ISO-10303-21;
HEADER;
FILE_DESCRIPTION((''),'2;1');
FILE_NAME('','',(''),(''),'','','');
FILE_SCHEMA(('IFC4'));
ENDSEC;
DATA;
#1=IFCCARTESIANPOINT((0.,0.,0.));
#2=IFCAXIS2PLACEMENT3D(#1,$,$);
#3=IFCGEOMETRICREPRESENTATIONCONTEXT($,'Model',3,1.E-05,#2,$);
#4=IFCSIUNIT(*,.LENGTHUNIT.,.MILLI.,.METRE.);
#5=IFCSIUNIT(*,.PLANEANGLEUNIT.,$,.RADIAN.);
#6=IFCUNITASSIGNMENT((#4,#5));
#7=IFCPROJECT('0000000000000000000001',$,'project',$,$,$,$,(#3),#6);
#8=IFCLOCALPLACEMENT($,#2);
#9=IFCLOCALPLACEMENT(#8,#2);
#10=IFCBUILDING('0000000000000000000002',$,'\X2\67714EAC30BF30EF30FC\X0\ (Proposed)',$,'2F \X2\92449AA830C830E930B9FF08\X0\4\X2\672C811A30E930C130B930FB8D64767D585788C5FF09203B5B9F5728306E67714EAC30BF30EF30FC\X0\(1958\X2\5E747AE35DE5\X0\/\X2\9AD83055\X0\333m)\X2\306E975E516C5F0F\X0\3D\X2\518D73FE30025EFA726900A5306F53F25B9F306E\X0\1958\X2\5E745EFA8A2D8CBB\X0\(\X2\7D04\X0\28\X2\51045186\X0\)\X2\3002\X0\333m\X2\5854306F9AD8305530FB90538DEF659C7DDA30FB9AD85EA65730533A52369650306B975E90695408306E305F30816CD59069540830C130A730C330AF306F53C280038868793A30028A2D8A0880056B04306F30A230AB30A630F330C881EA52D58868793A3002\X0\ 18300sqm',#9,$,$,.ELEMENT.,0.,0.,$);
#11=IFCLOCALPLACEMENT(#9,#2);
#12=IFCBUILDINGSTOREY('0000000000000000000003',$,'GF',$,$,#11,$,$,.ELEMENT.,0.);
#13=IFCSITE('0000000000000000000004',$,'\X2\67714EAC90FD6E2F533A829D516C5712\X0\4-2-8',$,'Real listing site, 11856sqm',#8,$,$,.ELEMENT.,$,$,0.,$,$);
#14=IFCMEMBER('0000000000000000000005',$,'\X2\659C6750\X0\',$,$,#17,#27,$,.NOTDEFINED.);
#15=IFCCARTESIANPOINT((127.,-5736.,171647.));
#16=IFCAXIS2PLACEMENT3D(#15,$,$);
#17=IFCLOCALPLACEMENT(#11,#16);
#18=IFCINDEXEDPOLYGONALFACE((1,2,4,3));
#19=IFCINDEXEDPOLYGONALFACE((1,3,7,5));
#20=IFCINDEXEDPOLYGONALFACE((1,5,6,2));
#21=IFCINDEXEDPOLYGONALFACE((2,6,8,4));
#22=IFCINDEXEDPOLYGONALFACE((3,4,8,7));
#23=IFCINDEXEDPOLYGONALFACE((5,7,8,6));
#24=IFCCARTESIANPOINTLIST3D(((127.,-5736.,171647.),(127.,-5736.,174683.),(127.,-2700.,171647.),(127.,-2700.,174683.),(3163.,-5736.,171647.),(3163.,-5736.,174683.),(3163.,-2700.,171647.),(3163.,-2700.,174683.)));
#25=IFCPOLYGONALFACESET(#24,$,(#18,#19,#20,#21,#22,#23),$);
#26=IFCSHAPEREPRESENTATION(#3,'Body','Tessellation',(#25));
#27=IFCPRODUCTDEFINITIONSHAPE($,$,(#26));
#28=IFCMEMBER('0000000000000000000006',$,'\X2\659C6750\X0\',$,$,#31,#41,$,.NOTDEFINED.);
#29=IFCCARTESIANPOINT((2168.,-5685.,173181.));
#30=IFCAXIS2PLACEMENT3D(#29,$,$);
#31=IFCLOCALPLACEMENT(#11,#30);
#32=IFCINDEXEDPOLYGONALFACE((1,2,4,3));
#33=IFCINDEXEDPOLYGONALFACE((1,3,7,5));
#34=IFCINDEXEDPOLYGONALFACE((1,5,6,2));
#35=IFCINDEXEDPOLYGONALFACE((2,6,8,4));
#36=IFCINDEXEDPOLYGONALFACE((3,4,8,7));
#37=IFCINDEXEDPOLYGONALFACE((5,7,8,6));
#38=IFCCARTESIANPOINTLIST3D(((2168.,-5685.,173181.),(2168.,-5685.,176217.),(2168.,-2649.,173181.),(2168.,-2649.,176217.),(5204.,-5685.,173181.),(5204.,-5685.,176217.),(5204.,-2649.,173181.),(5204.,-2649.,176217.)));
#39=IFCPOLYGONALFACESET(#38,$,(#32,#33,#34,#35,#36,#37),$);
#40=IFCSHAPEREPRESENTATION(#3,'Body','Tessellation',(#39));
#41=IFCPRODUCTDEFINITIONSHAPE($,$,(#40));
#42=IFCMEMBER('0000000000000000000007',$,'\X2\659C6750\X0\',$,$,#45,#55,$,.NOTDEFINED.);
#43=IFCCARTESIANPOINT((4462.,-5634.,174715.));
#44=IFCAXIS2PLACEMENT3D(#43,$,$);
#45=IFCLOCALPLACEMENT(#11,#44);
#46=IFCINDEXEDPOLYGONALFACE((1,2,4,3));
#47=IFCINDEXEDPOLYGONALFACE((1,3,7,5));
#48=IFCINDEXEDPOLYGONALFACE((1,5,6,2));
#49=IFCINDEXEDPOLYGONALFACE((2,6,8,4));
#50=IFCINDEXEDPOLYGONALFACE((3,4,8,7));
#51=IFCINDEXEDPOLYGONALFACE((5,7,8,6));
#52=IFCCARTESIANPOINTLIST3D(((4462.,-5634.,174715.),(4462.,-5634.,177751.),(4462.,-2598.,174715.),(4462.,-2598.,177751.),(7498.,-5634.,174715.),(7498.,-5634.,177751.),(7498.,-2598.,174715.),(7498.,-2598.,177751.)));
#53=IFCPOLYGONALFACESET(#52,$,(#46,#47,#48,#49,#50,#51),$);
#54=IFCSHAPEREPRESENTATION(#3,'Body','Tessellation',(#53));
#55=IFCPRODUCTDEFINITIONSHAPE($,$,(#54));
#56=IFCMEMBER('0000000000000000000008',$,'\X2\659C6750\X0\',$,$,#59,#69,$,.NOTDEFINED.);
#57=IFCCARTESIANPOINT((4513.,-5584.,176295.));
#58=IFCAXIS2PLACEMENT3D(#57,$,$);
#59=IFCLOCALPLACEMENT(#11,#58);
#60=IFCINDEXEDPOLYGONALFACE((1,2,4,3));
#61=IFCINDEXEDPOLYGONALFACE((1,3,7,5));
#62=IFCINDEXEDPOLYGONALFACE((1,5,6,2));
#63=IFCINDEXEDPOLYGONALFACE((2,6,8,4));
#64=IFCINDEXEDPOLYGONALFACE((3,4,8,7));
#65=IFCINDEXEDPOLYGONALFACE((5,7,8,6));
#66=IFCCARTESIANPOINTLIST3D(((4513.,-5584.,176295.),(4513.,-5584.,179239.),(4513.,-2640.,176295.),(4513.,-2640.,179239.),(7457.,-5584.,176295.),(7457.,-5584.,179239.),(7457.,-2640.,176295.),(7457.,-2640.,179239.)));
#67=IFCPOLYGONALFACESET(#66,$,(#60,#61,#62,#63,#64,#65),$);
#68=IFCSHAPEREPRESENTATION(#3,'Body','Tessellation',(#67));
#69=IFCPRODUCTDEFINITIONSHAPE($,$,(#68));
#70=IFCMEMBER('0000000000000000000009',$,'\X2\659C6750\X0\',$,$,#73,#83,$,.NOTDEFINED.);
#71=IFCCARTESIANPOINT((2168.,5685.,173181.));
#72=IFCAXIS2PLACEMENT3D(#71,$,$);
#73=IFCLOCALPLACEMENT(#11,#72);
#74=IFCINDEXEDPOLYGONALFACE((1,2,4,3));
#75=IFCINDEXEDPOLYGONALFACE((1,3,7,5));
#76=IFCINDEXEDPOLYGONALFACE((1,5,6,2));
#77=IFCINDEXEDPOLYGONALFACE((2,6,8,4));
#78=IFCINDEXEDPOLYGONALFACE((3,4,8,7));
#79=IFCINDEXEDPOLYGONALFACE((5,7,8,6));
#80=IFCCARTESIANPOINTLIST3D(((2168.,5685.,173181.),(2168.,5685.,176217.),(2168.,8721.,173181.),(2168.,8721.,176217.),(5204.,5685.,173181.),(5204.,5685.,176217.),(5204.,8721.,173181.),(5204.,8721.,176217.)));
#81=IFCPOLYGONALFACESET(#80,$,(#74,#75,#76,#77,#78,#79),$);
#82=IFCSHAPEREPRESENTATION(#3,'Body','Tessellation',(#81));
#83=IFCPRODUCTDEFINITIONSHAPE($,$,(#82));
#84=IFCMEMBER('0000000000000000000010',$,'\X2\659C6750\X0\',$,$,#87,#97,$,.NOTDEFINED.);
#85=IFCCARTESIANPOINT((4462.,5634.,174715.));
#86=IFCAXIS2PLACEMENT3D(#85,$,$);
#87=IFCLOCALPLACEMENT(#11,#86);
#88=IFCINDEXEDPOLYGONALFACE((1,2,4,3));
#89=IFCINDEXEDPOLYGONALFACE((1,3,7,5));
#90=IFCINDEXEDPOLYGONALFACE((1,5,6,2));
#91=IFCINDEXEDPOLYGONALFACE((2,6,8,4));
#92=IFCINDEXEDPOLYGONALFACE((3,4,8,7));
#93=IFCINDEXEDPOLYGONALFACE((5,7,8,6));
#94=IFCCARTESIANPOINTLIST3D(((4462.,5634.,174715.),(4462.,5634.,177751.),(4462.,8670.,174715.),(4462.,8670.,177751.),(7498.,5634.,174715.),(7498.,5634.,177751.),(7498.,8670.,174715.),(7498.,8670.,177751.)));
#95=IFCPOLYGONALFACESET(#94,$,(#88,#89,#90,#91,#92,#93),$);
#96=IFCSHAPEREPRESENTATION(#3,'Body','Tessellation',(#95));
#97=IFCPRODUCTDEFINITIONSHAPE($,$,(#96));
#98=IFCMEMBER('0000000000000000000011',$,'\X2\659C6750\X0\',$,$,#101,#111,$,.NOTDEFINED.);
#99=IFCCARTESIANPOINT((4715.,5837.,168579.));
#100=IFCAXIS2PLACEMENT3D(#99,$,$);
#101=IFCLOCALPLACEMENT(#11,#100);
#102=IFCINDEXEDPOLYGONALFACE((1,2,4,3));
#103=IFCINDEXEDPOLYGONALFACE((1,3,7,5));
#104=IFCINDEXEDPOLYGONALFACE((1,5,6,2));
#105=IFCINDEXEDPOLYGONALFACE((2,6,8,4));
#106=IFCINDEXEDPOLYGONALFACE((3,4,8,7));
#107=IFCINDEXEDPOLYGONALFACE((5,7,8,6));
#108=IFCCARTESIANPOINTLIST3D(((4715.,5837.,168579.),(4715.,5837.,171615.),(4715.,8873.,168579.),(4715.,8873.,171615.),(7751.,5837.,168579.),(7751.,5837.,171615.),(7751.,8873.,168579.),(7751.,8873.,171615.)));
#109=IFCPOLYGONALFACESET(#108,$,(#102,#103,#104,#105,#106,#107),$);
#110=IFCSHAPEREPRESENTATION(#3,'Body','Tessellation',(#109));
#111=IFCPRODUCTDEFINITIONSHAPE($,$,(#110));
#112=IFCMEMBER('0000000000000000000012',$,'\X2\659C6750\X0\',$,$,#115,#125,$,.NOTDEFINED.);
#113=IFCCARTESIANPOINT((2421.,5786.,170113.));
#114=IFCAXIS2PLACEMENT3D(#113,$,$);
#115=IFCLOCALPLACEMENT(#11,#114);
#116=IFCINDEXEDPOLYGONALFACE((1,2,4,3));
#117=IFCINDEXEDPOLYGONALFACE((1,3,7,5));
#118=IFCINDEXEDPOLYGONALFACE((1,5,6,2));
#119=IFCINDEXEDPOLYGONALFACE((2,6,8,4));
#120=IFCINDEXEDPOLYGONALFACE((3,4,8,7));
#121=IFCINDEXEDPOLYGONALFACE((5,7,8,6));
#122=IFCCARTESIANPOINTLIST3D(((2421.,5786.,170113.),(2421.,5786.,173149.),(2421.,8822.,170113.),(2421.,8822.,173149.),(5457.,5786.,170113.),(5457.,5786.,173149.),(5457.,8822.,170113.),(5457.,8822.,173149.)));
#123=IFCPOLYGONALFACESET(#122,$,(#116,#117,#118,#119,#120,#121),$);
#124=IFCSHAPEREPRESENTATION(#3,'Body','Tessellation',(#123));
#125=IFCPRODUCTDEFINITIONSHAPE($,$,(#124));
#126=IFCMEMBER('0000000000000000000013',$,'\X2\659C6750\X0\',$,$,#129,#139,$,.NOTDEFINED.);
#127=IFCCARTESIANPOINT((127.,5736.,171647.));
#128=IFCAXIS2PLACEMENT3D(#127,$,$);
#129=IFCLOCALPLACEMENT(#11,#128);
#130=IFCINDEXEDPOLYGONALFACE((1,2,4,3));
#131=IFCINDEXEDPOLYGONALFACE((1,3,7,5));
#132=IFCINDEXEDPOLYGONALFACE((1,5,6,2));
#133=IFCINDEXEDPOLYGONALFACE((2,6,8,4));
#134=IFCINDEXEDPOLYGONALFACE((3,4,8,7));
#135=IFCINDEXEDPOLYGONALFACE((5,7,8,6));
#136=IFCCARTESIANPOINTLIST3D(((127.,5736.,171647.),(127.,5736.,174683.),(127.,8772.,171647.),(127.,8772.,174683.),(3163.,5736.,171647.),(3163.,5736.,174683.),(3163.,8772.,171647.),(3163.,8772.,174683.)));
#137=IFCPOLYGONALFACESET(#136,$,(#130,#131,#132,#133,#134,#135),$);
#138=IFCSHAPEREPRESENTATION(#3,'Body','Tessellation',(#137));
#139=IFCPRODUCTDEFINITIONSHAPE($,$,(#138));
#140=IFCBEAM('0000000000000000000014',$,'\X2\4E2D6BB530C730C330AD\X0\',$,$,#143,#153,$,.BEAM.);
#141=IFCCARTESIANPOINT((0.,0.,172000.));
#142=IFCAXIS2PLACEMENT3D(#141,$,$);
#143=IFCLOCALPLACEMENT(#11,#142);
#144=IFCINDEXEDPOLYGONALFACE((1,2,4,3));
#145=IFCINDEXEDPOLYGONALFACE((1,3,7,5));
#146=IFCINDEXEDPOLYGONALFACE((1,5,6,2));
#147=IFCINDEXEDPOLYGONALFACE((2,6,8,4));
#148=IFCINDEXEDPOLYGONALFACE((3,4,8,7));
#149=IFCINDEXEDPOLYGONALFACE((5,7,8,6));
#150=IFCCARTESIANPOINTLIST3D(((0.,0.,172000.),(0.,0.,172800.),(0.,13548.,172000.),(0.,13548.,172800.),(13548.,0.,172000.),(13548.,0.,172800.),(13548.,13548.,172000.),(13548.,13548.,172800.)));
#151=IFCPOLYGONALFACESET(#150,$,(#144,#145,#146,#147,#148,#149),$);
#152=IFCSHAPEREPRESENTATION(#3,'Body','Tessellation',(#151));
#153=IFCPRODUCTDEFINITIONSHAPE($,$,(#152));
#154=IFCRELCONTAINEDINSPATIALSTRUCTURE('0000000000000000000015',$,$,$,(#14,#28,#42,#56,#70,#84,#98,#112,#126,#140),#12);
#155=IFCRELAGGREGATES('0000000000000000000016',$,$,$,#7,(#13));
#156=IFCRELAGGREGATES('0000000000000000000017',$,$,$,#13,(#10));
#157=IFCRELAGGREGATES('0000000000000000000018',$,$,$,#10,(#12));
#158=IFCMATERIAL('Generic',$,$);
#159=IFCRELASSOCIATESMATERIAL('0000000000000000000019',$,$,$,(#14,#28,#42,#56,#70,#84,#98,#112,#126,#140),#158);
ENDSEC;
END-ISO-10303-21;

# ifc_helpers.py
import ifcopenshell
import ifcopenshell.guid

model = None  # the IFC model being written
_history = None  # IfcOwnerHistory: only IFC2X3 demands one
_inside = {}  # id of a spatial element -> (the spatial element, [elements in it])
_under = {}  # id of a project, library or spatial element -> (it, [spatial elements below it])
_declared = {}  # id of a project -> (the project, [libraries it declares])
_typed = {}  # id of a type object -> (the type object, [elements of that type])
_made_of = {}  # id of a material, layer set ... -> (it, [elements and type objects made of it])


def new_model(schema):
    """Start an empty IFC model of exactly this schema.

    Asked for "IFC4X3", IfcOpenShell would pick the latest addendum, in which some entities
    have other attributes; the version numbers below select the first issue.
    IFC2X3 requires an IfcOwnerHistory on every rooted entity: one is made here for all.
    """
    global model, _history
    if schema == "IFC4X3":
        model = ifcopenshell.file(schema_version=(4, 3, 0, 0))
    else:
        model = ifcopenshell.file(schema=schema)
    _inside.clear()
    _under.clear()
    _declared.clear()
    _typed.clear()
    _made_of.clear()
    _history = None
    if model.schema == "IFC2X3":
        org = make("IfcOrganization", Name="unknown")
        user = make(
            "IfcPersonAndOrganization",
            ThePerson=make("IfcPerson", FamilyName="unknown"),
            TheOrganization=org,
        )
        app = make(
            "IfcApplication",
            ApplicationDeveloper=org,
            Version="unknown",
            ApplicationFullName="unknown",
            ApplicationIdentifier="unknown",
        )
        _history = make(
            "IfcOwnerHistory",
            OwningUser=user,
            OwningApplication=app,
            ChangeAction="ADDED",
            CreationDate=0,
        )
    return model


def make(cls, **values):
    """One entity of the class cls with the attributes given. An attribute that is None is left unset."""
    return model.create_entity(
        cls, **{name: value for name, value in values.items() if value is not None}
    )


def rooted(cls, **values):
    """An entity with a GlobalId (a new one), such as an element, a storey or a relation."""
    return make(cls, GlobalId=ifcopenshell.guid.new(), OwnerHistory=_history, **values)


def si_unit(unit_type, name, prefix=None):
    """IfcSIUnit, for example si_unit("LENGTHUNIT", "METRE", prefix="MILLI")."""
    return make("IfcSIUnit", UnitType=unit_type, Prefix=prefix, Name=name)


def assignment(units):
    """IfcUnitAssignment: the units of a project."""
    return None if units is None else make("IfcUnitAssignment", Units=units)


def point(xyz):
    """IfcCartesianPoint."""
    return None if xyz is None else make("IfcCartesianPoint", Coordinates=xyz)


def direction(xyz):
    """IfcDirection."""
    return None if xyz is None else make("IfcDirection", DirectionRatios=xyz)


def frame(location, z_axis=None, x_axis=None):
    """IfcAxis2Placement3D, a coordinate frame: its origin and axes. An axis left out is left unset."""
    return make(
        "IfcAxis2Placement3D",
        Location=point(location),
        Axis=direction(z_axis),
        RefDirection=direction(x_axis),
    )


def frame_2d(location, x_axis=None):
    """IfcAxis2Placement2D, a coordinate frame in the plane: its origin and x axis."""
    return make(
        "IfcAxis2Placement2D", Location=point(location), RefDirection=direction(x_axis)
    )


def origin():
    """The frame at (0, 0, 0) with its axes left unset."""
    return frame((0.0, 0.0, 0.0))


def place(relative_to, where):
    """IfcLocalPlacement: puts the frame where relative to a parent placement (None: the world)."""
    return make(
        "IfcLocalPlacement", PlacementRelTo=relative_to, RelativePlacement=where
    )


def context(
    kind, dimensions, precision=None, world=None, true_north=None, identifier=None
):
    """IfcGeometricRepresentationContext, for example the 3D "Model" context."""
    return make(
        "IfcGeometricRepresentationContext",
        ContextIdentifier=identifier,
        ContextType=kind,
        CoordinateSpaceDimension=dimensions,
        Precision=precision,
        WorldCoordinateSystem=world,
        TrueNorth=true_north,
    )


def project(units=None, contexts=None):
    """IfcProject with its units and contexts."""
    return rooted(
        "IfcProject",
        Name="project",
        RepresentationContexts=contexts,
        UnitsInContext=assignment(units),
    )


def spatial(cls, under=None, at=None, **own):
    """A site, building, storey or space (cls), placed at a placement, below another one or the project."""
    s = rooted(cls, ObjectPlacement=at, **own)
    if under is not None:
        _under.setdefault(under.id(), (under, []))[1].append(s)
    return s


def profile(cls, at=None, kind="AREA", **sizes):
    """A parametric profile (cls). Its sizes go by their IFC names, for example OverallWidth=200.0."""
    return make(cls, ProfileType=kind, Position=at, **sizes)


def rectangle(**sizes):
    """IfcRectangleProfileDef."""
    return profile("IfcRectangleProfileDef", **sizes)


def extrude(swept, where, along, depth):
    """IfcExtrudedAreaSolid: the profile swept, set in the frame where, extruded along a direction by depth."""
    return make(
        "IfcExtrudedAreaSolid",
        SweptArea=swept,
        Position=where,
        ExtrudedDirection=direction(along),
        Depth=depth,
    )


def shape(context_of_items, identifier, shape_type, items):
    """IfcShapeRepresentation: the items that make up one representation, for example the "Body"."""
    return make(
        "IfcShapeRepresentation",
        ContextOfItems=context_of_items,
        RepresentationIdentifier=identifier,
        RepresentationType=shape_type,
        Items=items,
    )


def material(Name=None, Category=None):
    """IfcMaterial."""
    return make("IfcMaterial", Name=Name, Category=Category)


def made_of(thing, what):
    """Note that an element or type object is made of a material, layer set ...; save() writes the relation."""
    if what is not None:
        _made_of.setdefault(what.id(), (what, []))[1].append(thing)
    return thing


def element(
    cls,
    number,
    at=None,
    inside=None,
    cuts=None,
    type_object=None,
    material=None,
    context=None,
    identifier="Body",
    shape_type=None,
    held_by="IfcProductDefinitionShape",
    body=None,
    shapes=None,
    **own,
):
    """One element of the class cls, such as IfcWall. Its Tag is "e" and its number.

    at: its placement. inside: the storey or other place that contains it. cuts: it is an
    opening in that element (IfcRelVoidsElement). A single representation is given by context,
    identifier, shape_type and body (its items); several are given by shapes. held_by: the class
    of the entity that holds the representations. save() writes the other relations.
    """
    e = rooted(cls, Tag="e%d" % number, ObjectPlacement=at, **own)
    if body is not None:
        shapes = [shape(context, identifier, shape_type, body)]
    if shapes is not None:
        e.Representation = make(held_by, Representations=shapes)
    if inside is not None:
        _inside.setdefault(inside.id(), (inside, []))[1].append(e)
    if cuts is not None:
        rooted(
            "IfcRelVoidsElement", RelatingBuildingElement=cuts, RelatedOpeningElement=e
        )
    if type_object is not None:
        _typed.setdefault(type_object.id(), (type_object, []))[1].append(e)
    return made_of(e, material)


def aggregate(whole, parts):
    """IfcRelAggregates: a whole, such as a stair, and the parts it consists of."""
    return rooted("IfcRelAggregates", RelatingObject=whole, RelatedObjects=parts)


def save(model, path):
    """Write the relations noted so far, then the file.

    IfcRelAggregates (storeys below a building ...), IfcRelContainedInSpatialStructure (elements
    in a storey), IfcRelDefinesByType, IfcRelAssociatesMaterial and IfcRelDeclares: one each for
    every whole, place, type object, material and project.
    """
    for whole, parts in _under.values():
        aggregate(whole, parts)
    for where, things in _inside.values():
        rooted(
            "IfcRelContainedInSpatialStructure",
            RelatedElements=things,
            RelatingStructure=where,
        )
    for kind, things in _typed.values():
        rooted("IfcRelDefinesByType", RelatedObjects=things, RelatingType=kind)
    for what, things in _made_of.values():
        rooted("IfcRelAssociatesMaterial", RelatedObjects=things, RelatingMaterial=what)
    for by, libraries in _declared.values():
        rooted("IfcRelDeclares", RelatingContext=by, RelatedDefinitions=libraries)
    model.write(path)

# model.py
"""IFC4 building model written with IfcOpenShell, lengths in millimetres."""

from ifc_helpers import new_model, si_unit, frame, frame_2d, origin, place, context, project, spatial, rectangle, extrude, material, element, save


model = new_model("IFC4")

# Units and contexts
model_context = context("Model", 3, precision=1e-05, world=origin())
ifc_project = project(units=[si_unit("LENGTHUNIT", "METRE", prefix="MILLI"), si_unit("PLANEANGLEUNIT", "RADIAN")], contexts=[model_context])

# Site, building, storey
site_placement = place(None, origin())
site = spatial("IfcSite", under=ifc_project, at=site_placement, Name="東京都港区芝公園4-2-8", ObjectType="Real listing site, 11856sqm", CompositionType="ELEMENT", RefElevation=0.0)
building_placement = place(site_placement, origin())
building = spatial("IfcBuilding", under=site, at=building_placement, Name="東京タワー (Proposed)", ObjectType="2F 鉄骨トラス（4本脚ラチス・赤白塗装）※実在の東京タワー(1958年竣工/高さ333m)の非公式3D再現。建物¥は史実の1958年建設費(約28億円)。333m塔は高さ・道路斜線・高度地区制限に非適合のため法適合チェックは参考表示。設計者欄はアカウント自動表示。 18300sqm", CompositionType="ELEMENT", ElevationOfRefHeight=0.0, ElevationOfTerrain=0.0)
storey_placement = place(building_placement, origin())
storey = spatial("IfcBuildingStorey", under=building, at=storey_placement, Name="GF", CompositionType="ELEMENT", Elevation=0.0)

# Shared definitions
ifc_material = material(Name="Generic")

# Members
member_1_placement = place(storey_placement, frame((127.0, -5736.0, 171647.0)))
element("IfcMember", 1, at=member_1_placement, inside=storey, material=ifc_material, Name="斜材", PredefinedType="NOTDEFINED", context=model_context, shape_type="SweptSolid", body=[
    extrude(rectangle(XDim=3036.0, YDim=3036.0, at=frame_2d((1518.0, 1518.0))), frame((127.0, -5736.0, 171647.0)), (0.0, 0.0, 1.0), 3036.0),
])
member_2_placement = place(storey_placement, frame((2168.0, -5685.0, 173181.0)))
element("IfcMember", 2, at=member_2_placement, inside=storey, material=ifc_material, Name="斜材", PredefinedType="NOTDEFINED", context=model_context, shape_type="SweptSolid", body=[
    extrude(rectangle(XDim=3036.0, YDim=3036.0, at=frame_2d((1518.0, 1518.0))), frame((2168.0, -5685.0, 173181.0)), (0.0, 0.0, 1.0), 3036.0),
])
member_3_placement = place(storey_placement, frame((4462.0, -5634.0, 174715.0)))
element("IfcMember", 3, at=member_3_placement, inside=storey, material=ifc_material, Name="斜材", PredefinedType="NOTDEFINED", context=model_context, shape_type="SweptSolid", body=[
    extrude(rectangle(XDim=3036.0, YDim=3036.0, at=frame_2d((1518.0, 1518.0))), frame((4462.0, -5634.0, 174715.0)), (0.0, 0.0, 1.0), 3036.0),
])
member_4_placement = place(storey_placement, frame((4513.0, -5584.0, 176295.0)))
element("IfcMember", 4, at=member_4_placement, inside=storey, material=ifc_material, Name="斜材", PredefinedType="NOTDEFINED", context=model_context, shape_type="SweptSolid", body=[
    extrude(rectangle(XDim=2944.0, YDim=2944.0, at=frame_2d((1472.0, 1472.0))), frame((4513.0, -5584.0, 176295.0)), (0.0, 0.0, 1.0), 2944.0),
])
member_5_placement = place(storey_placement, frame((2168.0, 5685.0, 173181.0)))
element("IfcMember", 5, at=member_5_placement, inside=storey, material=ifc_material, Name="斜材", PredefinedType="NOTDEFINED", context=model_context, shape_type="SweptSolid", body=[
    extrude(rectangle(XDim=3036.0, YDim=3036.0, at=frame_2d((1518.0, 1518.0))), frame((2168.0, 5685.0, 173181.0)), (0.0, 0.0, 1.0), 3036.0),
])
member_6_placement = place(storey_placement, frame((4462.0, 5634.0, 174715.0)))
element("IfcMember", 6, at=member_6_placement, inside=storey, material=ifc_material, Name="斜材", PredefinedType="NOTDEFINED", context=model_context, shape_type="SweptSolid", body=[
    extrude(rectangle(XDim=3036.0, YDim=3036.0, at=frame_2d((1518.0, 1518.0))), frame((4462.0, 5634.0, 174715.0)), (0.0, 0.0, 1.0), 3036.0),
])
member_7_placement = place(storey_placement, frame((4715.0, 5837.0, 168579.0)))
element("IfcMember", 7, at=member_7_placement, inside=storey, material=ifc_material, Name="斜材", PredefinedType="NOTDEFINED", context=model_context, shape_type="SweptSolid", body=[
    extrude(rectangle(XDim=3036.0, YDim=3036.0, at=frame_2d((1518.0, 1518.0))), frame((4715.0, 5837.0, 168579.0)), (0.0, 0.0, 1.0), 3036.0),
])
member_8_placement = place(storey_placement, frame((2421.0, 5786.0, 170113.0)))
element("IfcMember", 8, at=member_8_placement, inside=storey, material=ifc_material, Name="斜材", PredefinedType="NOTDEFINED", context=model_context, shape_type="SweptSolid", body=[
    extrude(rectangle(XDim=3036.0, YDim=3036.0, at=frame_2d((1518.0, 1518.0))), frame((2421.0, 5786.0, 170113.0)), (0.0, 0.0, 1.0), 3036.0),
])
member_9_placement = place(storey_placement, frame((127.0, 5736.0, 171647.0)))
element("IfcMember", 9, at=member_9_placement, inside=storey, material=ifc_material, Name="斜材", PredefinedType="NOTDEFINED", context=model_context, shape_type="SweptSolid", body=[
    extrude(rectangle(XDim=3036.0, YDim=3036.0, at=frame_2d((1518.0, 1518.0))), frame((127.0, 5736.0, 171647.0)), (0.0, 0.0, 1.0), 3036.0),
])

# Beam
beam_1_placement = place(storey_placement, frame((0.0, 0.0, 172000.0)))
element("IfcBeam", 10, at=beam_1_placement, inside=storey, material=ifc_material, Name="中段デッキ", PredefinedType="BEAM", context=model_context, shape_type="SweptSolid", body=[
    extrude(rectangle(XDim=13548.0, YDim=13548.0, at=frame_2d((6774.0, 6774.0))), frame((0.0, 0.0, 172000.0)), (0.0, 0.0, 1.0), 800.0),
])

save(model, "model.ifc")
